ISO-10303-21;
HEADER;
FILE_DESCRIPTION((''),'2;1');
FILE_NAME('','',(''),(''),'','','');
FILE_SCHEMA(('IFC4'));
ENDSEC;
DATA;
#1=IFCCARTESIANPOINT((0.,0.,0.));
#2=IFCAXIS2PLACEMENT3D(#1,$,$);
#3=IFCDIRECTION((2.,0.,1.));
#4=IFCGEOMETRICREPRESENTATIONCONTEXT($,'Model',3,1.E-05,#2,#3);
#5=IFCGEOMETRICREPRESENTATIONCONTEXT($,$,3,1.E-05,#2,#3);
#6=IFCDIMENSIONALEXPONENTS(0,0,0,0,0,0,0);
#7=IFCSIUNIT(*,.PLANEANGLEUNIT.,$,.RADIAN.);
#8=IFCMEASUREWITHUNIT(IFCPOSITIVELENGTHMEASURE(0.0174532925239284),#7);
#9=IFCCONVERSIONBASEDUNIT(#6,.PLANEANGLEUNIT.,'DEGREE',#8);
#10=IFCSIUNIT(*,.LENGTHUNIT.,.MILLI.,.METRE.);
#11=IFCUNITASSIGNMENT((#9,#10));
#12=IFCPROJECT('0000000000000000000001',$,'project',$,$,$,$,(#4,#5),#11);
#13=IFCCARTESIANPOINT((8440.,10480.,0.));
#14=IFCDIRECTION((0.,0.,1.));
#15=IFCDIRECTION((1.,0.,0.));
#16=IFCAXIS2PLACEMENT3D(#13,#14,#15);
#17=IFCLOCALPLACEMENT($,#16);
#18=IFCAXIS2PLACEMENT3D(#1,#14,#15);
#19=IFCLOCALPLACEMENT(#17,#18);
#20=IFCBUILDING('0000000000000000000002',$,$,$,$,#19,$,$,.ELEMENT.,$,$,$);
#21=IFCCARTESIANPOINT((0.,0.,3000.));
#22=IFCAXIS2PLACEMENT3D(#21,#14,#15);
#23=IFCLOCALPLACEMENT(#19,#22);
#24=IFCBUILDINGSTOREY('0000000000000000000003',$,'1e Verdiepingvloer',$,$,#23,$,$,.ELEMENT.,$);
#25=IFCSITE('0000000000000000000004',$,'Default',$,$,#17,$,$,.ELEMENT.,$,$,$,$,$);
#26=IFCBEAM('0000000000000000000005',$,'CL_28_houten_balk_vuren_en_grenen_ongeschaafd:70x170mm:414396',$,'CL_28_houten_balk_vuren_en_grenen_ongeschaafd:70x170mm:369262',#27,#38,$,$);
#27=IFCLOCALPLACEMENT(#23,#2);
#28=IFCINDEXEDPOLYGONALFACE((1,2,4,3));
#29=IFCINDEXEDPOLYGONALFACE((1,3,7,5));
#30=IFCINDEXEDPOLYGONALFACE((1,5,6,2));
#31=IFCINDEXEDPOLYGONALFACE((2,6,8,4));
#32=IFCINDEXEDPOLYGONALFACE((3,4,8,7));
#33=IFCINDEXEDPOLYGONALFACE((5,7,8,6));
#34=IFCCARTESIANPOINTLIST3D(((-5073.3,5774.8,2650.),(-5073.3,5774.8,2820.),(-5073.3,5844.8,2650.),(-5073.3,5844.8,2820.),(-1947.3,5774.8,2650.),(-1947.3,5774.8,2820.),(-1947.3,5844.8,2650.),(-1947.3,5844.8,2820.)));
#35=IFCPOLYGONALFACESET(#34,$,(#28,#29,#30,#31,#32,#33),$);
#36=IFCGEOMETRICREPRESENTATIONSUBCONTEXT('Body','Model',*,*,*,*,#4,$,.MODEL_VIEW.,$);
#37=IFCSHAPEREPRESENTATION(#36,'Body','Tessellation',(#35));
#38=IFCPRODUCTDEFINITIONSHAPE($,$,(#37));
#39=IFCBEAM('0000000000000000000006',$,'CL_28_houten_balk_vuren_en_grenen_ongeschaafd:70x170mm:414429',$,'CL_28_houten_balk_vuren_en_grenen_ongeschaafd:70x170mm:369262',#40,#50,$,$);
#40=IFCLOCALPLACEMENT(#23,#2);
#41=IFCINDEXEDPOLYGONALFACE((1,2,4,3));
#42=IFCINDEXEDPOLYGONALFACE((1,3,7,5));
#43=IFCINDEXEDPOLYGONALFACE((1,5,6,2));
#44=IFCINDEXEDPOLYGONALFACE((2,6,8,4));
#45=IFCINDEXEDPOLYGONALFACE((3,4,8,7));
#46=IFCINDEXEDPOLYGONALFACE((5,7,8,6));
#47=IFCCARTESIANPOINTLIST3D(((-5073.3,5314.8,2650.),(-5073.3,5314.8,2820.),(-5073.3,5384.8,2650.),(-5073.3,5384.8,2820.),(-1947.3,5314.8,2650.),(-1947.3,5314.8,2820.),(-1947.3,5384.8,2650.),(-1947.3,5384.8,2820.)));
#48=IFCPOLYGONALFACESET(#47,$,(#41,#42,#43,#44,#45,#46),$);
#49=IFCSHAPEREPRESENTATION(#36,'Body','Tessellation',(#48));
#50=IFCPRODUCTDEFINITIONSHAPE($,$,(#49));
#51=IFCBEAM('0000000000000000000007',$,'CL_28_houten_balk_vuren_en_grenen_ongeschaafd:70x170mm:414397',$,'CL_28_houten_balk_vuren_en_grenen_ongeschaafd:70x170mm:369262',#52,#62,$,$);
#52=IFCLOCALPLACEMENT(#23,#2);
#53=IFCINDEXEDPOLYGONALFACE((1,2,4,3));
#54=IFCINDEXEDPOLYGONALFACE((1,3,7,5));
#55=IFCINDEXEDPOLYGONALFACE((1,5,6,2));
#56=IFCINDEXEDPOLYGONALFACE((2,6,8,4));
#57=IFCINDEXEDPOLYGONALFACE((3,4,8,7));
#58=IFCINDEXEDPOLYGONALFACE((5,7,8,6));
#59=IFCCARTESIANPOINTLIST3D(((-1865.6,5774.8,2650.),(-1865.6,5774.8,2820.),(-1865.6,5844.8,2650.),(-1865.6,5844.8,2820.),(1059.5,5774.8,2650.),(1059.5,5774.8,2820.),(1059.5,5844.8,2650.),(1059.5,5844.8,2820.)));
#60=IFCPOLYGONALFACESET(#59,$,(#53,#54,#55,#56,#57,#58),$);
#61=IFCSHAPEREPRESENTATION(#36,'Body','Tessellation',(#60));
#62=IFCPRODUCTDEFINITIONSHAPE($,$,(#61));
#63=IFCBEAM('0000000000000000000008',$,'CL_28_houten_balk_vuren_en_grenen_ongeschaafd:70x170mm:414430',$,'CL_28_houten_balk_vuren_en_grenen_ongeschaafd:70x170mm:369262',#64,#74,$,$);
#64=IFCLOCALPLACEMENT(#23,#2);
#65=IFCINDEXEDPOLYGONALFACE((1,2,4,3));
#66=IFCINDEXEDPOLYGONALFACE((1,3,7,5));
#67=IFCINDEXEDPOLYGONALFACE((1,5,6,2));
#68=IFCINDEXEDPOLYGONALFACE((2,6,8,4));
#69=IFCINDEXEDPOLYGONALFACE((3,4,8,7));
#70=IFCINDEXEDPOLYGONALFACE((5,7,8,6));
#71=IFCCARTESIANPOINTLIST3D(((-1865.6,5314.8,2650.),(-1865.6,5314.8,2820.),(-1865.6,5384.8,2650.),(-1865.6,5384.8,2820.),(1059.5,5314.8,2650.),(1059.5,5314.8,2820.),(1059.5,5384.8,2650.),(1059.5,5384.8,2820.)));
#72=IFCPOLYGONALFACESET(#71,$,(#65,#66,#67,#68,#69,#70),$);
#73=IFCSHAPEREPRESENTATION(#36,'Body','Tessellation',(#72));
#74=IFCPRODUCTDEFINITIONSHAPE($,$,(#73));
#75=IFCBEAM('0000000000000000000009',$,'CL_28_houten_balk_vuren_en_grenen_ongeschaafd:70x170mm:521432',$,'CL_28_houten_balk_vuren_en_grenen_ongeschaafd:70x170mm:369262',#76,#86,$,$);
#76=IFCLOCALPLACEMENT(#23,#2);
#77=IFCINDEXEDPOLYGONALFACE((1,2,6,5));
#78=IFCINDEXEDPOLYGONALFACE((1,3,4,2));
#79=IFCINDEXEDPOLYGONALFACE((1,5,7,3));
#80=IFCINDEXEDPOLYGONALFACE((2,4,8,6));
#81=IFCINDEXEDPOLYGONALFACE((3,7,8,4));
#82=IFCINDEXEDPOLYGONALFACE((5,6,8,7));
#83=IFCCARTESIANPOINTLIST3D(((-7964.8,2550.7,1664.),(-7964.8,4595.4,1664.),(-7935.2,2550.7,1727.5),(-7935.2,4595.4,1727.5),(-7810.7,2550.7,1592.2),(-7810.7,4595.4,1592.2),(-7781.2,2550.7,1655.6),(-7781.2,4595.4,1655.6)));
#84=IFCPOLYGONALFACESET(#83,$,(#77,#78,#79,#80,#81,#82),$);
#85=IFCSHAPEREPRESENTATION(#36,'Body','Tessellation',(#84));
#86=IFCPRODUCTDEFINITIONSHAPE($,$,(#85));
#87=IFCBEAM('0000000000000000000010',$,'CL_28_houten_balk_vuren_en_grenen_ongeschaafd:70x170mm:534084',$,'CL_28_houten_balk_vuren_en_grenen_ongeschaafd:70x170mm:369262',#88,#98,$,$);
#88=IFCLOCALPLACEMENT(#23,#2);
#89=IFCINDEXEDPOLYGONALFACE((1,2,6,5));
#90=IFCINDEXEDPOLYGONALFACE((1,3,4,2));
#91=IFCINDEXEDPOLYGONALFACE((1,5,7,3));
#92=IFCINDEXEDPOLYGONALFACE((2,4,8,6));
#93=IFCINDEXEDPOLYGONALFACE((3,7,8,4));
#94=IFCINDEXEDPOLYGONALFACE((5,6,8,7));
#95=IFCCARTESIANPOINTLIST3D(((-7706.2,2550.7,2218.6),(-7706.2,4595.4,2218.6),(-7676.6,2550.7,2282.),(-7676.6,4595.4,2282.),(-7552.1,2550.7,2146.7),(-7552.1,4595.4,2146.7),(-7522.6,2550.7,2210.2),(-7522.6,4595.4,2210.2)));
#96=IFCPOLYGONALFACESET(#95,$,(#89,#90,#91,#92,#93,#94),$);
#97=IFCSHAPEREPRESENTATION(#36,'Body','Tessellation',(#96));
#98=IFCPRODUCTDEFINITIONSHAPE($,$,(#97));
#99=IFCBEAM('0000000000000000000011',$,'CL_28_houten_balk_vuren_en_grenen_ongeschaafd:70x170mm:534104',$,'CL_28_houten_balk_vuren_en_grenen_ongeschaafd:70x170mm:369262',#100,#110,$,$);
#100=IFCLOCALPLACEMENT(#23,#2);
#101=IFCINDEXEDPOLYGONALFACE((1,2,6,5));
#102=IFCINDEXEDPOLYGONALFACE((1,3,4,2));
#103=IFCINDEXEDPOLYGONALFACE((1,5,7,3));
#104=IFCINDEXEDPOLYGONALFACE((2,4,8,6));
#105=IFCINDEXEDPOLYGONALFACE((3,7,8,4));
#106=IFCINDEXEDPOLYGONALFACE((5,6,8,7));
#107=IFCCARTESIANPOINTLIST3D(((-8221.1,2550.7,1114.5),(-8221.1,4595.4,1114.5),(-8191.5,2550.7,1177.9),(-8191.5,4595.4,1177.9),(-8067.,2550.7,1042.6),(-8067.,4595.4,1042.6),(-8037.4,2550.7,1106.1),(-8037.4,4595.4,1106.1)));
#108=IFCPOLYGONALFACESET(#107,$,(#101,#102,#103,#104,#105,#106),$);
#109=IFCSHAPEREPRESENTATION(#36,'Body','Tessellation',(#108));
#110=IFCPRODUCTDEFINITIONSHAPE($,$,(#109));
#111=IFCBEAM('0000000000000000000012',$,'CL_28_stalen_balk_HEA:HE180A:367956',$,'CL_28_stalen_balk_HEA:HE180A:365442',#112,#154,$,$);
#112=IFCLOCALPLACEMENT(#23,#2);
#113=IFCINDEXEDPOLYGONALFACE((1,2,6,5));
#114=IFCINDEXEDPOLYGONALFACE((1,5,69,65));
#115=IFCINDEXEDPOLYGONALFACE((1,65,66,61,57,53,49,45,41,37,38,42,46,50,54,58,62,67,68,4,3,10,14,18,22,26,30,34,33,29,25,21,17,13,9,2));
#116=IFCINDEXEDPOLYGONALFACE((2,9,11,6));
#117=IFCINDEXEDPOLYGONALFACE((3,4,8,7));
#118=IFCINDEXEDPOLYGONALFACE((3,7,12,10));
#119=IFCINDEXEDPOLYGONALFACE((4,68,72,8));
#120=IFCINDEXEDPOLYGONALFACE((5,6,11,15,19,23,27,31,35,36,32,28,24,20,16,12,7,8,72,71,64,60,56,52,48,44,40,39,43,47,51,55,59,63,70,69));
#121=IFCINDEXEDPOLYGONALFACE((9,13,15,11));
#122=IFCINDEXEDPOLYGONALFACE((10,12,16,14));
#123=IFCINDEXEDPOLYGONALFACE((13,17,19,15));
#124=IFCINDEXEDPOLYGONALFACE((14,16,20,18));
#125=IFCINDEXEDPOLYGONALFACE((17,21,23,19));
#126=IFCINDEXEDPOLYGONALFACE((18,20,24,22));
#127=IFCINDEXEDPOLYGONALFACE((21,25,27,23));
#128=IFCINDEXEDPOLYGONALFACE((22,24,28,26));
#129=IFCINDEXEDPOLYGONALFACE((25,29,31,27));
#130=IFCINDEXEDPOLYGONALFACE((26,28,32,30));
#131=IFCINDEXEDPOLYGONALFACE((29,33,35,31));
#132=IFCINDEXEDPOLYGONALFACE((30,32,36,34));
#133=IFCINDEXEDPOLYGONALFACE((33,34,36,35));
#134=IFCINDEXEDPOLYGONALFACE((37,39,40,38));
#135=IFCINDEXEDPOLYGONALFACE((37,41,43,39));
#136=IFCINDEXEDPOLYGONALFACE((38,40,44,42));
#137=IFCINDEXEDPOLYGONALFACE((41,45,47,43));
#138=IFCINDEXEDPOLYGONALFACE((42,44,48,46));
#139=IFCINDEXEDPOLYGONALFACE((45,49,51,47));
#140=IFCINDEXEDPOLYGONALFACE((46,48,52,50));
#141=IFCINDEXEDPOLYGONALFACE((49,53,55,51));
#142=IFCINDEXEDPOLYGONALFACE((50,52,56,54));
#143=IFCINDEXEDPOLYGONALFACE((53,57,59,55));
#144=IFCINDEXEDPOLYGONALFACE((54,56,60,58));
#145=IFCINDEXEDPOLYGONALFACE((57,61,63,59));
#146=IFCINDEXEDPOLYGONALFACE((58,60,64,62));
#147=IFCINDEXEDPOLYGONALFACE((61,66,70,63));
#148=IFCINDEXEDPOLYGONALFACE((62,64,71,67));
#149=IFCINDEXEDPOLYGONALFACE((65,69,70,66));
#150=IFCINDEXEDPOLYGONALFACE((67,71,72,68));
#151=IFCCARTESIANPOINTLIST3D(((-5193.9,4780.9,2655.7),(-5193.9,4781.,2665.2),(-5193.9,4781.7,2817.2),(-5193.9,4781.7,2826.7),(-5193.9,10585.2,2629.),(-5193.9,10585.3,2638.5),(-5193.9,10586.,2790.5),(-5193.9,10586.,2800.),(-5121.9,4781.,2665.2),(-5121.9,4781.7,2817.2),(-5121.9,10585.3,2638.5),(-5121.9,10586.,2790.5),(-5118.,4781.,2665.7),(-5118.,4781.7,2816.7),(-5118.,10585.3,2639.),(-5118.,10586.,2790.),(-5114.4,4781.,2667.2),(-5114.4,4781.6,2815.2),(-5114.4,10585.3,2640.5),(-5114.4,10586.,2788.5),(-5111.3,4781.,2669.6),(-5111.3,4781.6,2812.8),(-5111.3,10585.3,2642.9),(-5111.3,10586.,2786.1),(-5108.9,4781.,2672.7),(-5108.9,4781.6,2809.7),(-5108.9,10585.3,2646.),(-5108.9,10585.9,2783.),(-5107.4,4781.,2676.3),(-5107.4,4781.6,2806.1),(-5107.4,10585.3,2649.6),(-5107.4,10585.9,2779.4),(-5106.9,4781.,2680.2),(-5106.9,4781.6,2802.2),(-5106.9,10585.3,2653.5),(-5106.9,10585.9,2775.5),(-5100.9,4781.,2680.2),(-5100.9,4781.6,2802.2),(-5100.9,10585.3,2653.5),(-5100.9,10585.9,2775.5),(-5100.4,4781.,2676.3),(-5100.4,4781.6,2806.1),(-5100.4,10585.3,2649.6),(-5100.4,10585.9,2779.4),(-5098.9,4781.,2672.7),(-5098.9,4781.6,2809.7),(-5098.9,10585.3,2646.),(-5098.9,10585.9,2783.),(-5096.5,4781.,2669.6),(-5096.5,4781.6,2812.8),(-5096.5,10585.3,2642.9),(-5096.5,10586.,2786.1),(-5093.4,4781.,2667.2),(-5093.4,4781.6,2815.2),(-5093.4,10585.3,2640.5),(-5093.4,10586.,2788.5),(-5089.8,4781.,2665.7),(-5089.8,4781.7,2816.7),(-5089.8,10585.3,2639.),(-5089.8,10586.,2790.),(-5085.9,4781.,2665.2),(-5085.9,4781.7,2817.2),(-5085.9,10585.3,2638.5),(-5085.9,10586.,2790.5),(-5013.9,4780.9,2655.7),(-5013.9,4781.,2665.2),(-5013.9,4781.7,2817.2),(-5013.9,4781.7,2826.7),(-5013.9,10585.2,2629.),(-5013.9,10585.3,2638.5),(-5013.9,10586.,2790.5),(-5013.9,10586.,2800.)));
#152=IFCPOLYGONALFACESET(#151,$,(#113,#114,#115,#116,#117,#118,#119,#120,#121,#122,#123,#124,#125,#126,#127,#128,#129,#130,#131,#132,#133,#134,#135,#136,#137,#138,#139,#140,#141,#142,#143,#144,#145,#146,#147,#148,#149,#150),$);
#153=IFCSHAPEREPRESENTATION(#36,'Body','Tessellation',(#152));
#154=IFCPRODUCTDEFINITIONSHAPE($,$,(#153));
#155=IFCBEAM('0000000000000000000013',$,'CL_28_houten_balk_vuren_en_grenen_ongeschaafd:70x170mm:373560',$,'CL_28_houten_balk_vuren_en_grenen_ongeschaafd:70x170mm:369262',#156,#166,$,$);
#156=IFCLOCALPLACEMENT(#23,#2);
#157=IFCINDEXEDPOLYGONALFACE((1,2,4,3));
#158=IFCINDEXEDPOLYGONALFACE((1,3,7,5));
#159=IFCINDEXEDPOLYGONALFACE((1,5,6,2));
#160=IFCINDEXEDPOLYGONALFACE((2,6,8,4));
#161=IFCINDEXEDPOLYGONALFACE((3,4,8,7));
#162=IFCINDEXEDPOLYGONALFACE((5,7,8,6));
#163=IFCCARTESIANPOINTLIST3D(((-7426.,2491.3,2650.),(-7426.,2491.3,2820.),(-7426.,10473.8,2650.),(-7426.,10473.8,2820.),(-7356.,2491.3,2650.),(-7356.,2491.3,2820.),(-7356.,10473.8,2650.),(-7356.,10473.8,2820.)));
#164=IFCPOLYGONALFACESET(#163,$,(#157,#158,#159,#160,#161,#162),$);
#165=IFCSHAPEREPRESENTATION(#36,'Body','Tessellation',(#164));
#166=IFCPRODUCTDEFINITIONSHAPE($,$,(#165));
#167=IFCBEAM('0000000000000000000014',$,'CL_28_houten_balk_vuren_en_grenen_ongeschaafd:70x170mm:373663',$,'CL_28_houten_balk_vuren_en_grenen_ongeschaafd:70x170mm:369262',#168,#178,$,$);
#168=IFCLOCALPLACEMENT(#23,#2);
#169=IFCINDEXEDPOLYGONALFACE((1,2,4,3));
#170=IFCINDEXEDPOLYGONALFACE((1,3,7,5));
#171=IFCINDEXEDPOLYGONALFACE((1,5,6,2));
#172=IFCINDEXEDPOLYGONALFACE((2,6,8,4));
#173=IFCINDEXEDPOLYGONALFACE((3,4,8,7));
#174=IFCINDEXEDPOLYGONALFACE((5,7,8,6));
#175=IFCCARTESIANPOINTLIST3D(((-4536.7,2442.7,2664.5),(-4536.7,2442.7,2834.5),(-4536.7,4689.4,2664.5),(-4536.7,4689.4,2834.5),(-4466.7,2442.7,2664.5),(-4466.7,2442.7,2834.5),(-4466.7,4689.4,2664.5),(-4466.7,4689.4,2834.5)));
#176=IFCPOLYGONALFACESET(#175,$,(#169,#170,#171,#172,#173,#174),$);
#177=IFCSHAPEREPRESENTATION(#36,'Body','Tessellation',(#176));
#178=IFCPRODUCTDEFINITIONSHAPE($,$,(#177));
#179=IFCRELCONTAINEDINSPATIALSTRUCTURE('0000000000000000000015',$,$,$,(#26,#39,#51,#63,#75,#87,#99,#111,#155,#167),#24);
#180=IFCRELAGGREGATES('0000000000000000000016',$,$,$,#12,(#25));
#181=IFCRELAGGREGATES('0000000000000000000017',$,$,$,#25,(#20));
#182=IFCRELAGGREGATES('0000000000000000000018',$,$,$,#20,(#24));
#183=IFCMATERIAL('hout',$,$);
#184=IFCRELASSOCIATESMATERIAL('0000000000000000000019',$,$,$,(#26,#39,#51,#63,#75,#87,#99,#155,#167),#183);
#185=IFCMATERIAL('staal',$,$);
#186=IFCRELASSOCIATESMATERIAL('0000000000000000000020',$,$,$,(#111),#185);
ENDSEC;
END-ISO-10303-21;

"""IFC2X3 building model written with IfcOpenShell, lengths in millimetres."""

from ifc_helpers import new_model, entity, si_unit, converted_unit, direction, frame, frame_2d, origin, origin_with_axes, origin_2d_with_axis, place, context, subcontext, project, spatial, rectangle, i_section, extrude, source, transform, mapped, material, element, save


model = new_model("IFC2X3")

# Units and contexts
model_context = context("Model", 3, precision=1e-05, world=origin(), true_north=direction((2.0, 0.0, 1.0)))
context_of_model = context(None, 3, precision=1e-05, world=origin(), true_north=direction((2.0, 0.0, 1.0)))
body_context = subcontext(model_context, "Body", "Model", "MODEL_VIEW")
ifc_project = project(units=[converted_unit("PLANEANGLEUNIT", "DEGREE", entity("IfcPositiveLengthMeasure", 0.0174532925239284), si_unit("PLANEANGLEUNIT", "RADIAN"), dimensions=[0, 0, 0, 0, 0, 0, 0]), si_unit("LENGTHUNIT", "METRE", prefix="MILLI")], contexts=[model_context, context_of_model])

# Site, building, storey
site_placement = place(None, frame((8440.0, 10480.0, 0.0), z_axis=(0.0, 0.0, 1.0), x_axis=(1.0, 0.0, 0.0)))
site = spatial("IfcSite", under=ifc_project, at=site_placement, Name="Default", CompositionType="ELEMENT")
building_placement = place(site_placement, origin_with_axes())
building = spatial("IfcBuilding", under=site, at=building_placement, CompositionType="ELEMENT")
storey_placement = place(building_placement, frame((0.0, 0.0, 3000.0), z_axis=(0.0, 0.0, 1.0), x_axis=(1.0, 0.0, 0.0)))
storey = spatial("IfcBuildingStorey", under=building, at=storey_placement, Name="1e Verdiepingvloer", CompositionType="ELEMENT")

# Beams
ifc_material_1 = material(Name="hout")
shared_shape_1 = source(origin(), body_context, "Body", "SweptSolid", [
    extrude(rectangle(XDim=170.0, YDim=70.0, at=frame_2d((0.0, 0.0), x_axis=(1.0, 0.0))), frame((155.6, 0.0, -85.0), z_axis=(1.0, 0.0, 0.0), x_axis=(0.0, 0.0, -1.0)), (0.0, 0.0, 1.0), 3126.0),
])
for number, where, z_axis, x_axis, name in (
    (1, (-5228.9, 5809.8, 2820.0), (0.0, 0.0, 1.0), (1.0, 0.0, 0.0), "CL_28_houten_balk_vuren_en_grenen_ongeschaafd:70x170mm:414396"),
    (2, (-5228.9, 5349.8, 2820.0), (0.0, 0.0, 1.0), (1.0, 0.0, 0.0), "CL_28_houten_balk_vuren_en_grenen_ongeschaafd:70x170mm:414429"),
):
    element("IfcBeam", number, at=place(storey_placement, frame(where, z_axis=z_axis, x_axis=x_axis)), inside=storey, material=ifc_material_1, Name=name, ObjectType="CL_28_houten_balk_vuren_en_grenen_ongeschaafd:70x170mm:369262", context=body_context, shape_type="MappedRepresentation", body=[
        mapped(shared_shape_1, transform((0.0, 0.0, 0.0))),
    ])
shared_shape_2 = source(origin(), body_context, "Body", "SweptSolid", [
    extrude(rectangle(XDim=170.0, YDim=70.0, at=frame_2d((0.0, 0.0), x_axis=(1.0, 0.0))), frame((263.4, 0.0, -85.0), z_axis=(1.0, 0.0, 0.0), x_axis=(0.0, 0.0, -1.0)), (0.0, 0.0, 1.0), 2925.0),
])
for number, where, z_axis, x_axis, name in (
    (3, (-2128.9, 5809.8, 2820.0), (0.0, 0.0, 1.0), (1.0, 0.0, 0.0), "CL_28_houten_balk_vuren_en_grenen_ongeschaafd:70x170mm:414397"),
    (4, (-2128.9, 5349.8, 2820.0), (0.0, 0.0, 1.0), (1.0, 0.0, 0.0), "CL_28_houten_balk_vuren_en_grenen_ongeschaafd:70x170mm:414430"),
):
    element("IfcBeam", number, at=place(storey_placement, frame(where, z_axis=z_axis, x_axis=x_axis)), inside=storey, material=ifc_material_1, Name=name, ObjectType="CL_28_houten_balk_vuren_en_grenen_ongeschaafd:70x170mm:369262", context=body_context, shape_type="MappedRepresentation", body=[
        mapped(shared_shape_2, transform((0.0, 0.0, 0.0))),
    ])
shared_shape_3 = source(origin(), body_context, "Body", "SweptSolid", [
    extrude(rectangle(XDim=70.0, YDim=170.0, at=origin_2d_with_axis()), frame((69.9, -77.0, -35.9), z_axis=(1.0, 0.0, 0.0), x_axis=(0.0, -0.422618, 0.906308)), (0.0, 0.0, 1.0), 2044.8),
])
for number, where, z_axis, x_axis, name in (
    (5, (-7950.0, 2480.8, 1695.8), (0.0, 0.0, 1.0), (0.0, 1.0, 0.0), "CL_28_houten_balk_vuren_en_grenen_ongeschaafd:70x170mm:521432"),
    (6, (-7691.4, 2480.8, 2250.3), (0.0, 0.0, 1.0), (0.0, 1.0, 0.0), "CL_28_houten_balk_vuren_en_grenen_ongeschaafd:70x170mm:534084"),
    (7, (-8206.3, 2480.8, 1146.2), (0.0, 0.0, 1.0), (0.0, 1.0, 0.0), "CL_28_houten_balk_vuren_en_grenen_ongeschaafd:70x170mm:534104"),
):
    element("IfcBeam", number, at=place(storey_placement, frame(where, z_axis=z_axis, x_axis=x_axis)), inside=storey, material=ifc_material_1, Name=name, ObjectType="CL_28_houten_balk_vuren_en_grenen_ongeschaafd:70x170mm:369262", context=body_context, shape_type="MappedRepresentation", body=[
        mapped(shared_shape_3, transform((0.0, 0.0, 0.0))),
    ])
ifc_material_2 = material(Name="staal")
beam_1_placement = place(storey_placement, frame((-5103.9, 4939.9, 2826.0), z_axis=(0.0, 0.00461, 0.999989), x_axis=(0.0, 0.999989, -0.00461)))
element("IfcBeam", 8, at=beam_1_placement, inside=storey, material=ifc_material_2, Name="CL_28_stalen_balk_HEA:HE180A:367956", ObjectType="CL_28_stalen_balk_HEA:HE180A:365442", context=body_context, shape_type="SweptSolid", body=[
    extrude(i_section(OverallWidth=180.0, OverallDepth=171.0, WebThickness=6.0, FlangeThickness=9.5, FilletRadius=15.0, at=frame_2d((0.0, 0.0), x_axis=(0.0, 1.0))), frame((-158.2, 0.0, -85.5), z_axis=(1.0, 0.0, 0.0), x_axis=(0.0, 0.0, -1.0)), (0.0, 0.0, 1.0), 5804.4),
])
beam_2_placement = place(storey_placement, frame((-7391.0, 2480.8, 2820.0), z_axis=(0.0, 0.0, 1.0), x_axis=(0.0, 1.0, 0.0)))
element("IfcBeam", 9, at=beam_2_placement, inside=storey, material=ifc_material_1, Name="CL_28_houten_balk_vuren_en_grenen_ongeschaafd:70x170mm:373560", ObjectType="CL_28_houten_balk_vuren_en_grenen_ongeschaafd:70x170mm:369262", context=body_context, shape_type="SweptSolid", body=[
    extrude(rectangle(XDim=170.0, YDim=70.0, at=frame_2d((0.0, 0.0), x_axis=(1.0, 0.0))), frame((10.5, 0.0, -85.0), z_axis=(1.0, 0.0, 0.0), x_axis=(0.0, 0.0, -1.0)), (0.0, 0.0, 1.0), 7982.5),
])
beam_3_placement = place(storey_placement, frame((-4501.7, 2480.8, 2834.5), z_axis=(0.0, 0.0, 1.0), x_axis=(0.0, 1.0, 0.0)))
element("IfcBeam", 10, at=beam_3_placement, inside=storey, material=ifc_material_1, Name="CL_28_houten_balk_vuren_en_grenen_ongeschaafd:70x170mm:373663", ObjectType="CL_28_houten_balk_vuren_en_grenen_ongeschaafd:70x170mm:369262", context=body_context, shape_type="SweptSolid", body=[
    extrude(rectangle(XDim=170.0, YDim=70.0, at=frame_2d((0.0, 0.0), x_axis=(1.0, 0.0))), frame((-38.1, 0.0, -85.0), z_axis=(1.0, 0.0, 0.0), x_axis=(0.0, 0.0, -1.0)), (0.0, 0.0, 1.0), 2246.7),
])

save(model, "model.ifc")
